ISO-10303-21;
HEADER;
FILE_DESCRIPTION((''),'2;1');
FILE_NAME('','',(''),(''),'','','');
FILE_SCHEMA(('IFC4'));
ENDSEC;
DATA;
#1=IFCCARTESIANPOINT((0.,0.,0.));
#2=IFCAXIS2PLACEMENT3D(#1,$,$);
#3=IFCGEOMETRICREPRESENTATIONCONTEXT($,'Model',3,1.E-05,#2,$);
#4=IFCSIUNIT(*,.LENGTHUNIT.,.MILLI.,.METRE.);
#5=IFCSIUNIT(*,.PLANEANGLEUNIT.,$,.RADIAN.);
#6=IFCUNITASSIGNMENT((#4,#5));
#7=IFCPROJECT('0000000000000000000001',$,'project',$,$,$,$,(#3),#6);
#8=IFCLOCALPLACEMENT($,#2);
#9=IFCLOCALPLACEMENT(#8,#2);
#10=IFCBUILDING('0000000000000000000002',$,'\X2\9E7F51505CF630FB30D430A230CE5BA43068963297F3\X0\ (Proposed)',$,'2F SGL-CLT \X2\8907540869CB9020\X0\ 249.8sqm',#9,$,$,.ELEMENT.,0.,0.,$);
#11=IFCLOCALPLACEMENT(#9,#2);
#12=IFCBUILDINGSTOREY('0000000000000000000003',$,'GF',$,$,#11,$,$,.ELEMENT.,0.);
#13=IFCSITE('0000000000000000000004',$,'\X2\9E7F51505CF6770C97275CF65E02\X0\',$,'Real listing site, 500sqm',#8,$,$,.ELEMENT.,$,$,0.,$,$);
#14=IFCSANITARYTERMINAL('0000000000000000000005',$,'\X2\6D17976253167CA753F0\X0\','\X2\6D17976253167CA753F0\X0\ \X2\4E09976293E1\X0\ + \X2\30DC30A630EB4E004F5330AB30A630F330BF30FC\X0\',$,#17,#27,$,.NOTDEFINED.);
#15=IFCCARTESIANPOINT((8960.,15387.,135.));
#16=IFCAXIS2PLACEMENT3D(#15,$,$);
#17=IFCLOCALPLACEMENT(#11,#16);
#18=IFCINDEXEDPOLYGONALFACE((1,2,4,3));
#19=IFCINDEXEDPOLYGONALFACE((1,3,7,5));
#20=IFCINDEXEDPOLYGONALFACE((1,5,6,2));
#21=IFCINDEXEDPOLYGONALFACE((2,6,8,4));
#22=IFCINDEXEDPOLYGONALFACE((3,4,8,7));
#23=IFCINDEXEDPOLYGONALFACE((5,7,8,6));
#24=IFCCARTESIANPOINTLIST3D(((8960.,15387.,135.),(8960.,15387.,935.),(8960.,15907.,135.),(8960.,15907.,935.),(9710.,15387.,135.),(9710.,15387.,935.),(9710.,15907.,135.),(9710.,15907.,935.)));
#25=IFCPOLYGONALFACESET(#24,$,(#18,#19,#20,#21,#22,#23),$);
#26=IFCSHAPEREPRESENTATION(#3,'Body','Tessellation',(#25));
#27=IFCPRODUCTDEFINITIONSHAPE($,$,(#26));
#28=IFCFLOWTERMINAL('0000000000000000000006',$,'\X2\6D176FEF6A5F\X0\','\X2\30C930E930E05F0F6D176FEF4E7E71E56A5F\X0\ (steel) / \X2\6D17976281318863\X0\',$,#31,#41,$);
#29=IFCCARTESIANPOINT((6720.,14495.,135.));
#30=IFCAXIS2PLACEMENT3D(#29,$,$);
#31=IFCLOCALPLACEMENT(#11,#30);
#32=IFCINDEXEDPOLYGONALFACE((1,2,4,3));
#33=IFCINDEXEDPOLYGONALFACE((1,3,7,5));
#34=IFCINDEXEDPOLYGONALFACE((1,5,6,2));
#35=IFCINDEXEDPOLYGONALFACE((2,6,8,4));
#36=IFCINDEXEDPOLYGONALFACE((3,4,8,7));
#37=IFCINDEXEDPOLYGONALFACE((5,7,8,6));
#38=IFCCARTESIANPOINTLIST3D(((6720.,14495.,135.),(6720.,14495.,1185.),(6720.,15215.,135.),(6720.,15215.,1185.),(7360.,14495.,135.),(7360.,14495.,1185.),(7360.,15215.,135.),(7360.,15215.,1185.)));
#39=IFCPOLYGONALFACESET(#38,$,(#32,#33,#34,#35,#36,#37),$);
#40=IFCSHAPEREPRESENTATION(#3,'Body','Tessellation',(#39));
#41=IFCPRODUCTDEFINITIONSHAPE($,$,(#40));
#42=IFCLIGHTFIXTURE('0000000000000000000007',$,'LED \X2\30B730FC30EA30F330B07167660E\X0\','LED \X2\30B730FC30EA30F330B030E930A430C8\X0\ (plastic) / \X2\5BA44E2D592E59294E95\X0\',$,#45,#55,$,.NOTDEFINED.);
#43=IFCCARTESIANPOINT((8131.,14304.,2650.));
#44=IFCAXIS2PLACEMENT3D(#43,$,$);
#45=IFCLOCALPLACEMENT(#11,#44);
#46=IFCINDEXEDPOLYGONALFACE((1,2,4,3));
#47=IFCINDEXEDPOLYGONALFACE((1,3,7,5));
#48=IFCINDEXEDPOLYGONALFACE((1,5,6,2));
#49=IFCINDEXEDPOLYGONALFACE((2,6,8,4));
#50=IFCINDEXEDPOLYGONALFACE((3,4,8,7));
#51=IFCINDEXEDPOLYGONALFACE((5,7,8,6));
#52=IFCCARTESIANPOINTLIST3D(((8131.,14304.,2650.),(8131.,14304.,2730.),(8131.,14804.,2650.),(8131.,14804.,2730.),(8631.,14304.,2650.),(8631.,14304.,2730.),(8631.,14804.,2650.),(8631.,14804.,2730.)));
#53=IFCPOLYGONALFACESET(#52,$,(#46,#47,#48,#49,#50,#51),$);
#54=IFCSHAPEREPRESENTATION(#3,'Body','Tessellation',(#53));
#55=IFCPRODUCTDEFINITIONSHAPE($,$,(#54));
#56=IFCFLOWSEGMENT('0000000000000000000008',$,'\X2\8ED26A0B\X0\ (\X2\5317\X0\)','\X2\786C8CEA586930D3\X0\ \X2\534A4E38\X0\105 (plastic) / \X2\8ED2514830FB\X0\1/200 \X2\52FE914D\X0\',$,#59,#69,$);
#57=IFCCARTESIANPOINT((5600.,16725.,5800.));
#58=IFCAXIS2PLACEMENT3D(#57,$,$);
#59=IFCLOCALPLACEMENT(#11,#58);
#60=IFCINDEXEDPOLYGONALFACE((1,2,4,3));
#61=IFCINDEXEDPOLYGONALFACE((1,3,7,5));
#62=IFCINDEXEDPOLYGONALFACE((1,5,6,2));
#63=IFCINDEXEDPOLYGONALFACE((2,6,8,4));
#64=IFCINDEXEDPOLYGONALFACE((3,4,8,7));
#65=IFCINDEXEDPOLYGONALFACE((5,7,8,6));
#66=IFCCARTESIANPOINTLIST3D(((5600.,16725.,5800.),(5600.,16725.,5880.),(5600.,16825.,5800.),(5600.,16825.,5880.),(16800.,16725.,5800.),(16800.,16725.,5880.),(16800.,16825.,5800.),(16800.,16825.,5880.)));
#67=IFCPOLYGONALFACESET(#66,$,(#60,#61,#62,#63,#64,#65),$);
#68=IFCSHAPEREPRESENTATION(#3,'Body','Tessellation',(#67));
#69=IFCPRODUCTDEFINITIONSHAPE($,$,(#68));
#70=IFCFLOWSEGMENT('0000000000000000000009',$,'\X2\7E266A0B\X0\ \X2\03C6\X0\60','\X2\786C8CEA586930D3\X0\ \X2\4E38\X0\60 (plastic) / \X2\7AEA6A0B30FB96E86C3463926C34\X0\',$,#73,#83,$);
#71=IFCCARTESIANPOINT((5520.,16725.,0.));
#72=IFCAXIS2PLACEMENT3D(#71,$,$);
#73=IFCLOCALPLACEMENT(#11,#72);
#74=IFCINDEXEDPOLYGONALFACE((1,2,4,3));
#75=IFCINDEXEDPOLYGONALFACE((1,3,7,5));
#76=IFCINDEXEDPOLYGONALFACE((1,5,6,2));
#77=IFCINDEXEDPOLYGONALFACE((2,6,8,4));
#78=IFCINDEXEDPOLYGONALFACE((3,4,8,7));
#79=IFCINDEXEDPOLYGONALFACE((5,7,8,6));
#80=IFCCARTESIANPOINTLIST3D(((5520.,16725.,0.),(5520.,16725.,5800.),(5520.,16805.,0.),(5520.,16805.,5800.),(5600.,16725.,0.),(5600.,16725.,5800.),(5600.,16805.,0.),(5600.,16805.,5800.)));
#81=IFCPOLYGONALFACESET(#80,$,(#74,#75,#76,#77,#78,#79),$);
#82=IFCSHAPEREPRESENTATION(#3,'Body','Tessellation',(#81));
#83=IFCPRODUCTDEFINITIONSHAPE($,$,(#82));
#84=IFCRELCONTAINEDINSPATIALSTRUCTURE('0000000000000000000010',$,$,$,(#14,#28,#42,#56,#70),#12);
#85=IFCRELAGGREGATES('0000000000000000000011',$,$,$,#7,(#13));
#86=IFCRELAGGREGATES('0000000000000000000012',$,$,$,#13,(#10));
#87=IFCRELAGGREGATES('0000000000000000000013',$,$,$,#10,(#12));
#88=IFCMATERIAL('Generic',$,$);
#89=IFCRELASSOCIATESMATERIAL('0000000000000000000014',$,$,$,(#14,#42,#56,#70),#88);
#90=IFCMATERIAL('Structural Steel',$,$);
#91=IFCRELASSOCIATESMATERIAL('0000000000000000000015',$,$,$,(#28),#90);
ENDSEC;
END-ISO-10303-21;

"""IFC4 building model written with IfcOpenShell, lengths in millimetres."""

from ifc_helpers import new_model, si_unit, frame, frame_2d, origin, place, context, project, spatial, rectangle, extrude, material, element, save


model = new_model("IFC4")

# Units and contexts
model_context = context("Model", 3, precision=1e-05, world=origin())
ifc_project = project(units=[si_unit("LENGTHUNIT", "METRE", prefix="MILLI"), si_unit("PLANEANGLEUNIT", "RADIAN")], contexts=[model_context])

# Site, building, storey
site_placement = place(None, origin())
site = spatial("IfcSite", under=ifc_project, at=site_placement, Name="鹿児島県霧島市", ObjectType="Real listing site, 500sqm", CompositionType="ELEMENT", RefElevation=0.0)
building_placement = place(site_placement, origin())
building = spatial("IfcBuilding", under=site, at=building_placement, Name="鹿児島・ピアノ室と防音 (Proposed)", ObjectType="2F SGL-CLT 複合構造 249.8sqm", CompositionType="ELEMENT", ElevationOfRefHeight=0.0, ElevationOfTerrain=0.0)
storey_placement = place(building_placement, origin())
storey = spatial("IfcBuildingStorey", under=building, at=storey_placement, Name="GF", CompositionType="ELEMENT", Elevation=0.0)

# Sanitary terminal
ifc_material_1 = material(Name="Generic")
sanitary_terminal_placement = place(storey_placement, frame((8960.0, 15387.0, 135.0)))
element("IfcSanitaryTerminal", 1, at=sanitary_terminal_placement, inside=storey, material=ifc_material_1, Name="洗面化粧台", Description="洗面化粧台 三面鏡 + ボウル一体カウンター", PredefinedType="NOTDEFINED", context=model_context, shape_type="SweptSolid", body=[
    extrude(rectangle(XDim=750.0, YDim=520.0, at=frame_2d((375.0, 260.0))), frame((8960.0, 15387.0, 135.0)), (0.0, 0.0, 1.0), 800.0),
])

# Flow terminal
ifc_material_2 = material(Name="Structural Steel")
flow_terminal_placement = place(storey_placement, frame((6720.0, 14495.0, 135.0)))
element("IfcFlowTerminal", 2, at=flow_terminal_placement, inside=storey, material=ifc_material_2, Name="洗濯機", Description="ドラム式洗濯乾燥機 (steel) / 洗面脱衣", context=model_context, shape_type="SweptSolid", body=[
    extrude(rectangle(XDim=640.0, YDim=720.0, at=frame_2d((320.0, 360.0))), frame((6720.0, 14495.0, 135.0)), (0.0, 0.0, 1.0), 1050.0),
])

# Light fixture
light_fixture_placement = place(storey_placement, frame((8131.0, 14304.0, 2650.0)))
element("IfcLightFixture", 3, at=light_fixture_placement, inside=storey, material=ifc_material_1, Name="LED シーリング照明", Description="LED シーリングライト (plastic) / 室中央天井", PredefinedType="NOTDEFINED", context=model_context, shape_type="SweptSolid", body=[
    extrude(rectangle(XDim=500.0, YDim=500.0, at=frame_2d((250.0, 250.0))), frame((8131.0, 14304.0, 2650.0)), (0.0, 0.0, 1.0), 80.0),
])

# Flow segments
flow_segment_1_placement = place(storey_placement, frame((5600.0, 16725.0, 5800.0)))
element("IfcFlowSegment", 4, at=flow_segment_1_placement, inside=storey, material=ifc_material_1, Name="軒樋 (北)", Description="硬質塩ビ 半丸105 (plastic) / 軒先・1/200 勾配", context=model_context, shape_type="SweptSolid", body=[
    extrude(rectangle(XDim=11200.0, YDim=100.0, at=frame_2d((5600.0, 50.0))), frame((5600.0, 16725.0, 5800.0)), (0.0, 0.0, 1.0), 80.0),
])
flow_segment_2_placement = place(storey_placement, frame((5520.0, 16725.0, 0.0)))
element("IfcFlowSegment", 5, at=flow_segment_2_placement, inside=storey, material=ifc_material_1, Name="縦樋 φ60", Description="硬質塩ビ 丸60 (plastic) / 竪樋・雨水排水", context=model_context, shape_type="SweptSolid", body=[
    extrude(rectangle(XDim=80.0, YDim=80.0, at=frame_2d((40.0, 40.0))), frame((5520.0, 16725.0, 0.0)), (0.0, 0.0, 1.0), 5800.0),
])

save(model, "model.ifc")
